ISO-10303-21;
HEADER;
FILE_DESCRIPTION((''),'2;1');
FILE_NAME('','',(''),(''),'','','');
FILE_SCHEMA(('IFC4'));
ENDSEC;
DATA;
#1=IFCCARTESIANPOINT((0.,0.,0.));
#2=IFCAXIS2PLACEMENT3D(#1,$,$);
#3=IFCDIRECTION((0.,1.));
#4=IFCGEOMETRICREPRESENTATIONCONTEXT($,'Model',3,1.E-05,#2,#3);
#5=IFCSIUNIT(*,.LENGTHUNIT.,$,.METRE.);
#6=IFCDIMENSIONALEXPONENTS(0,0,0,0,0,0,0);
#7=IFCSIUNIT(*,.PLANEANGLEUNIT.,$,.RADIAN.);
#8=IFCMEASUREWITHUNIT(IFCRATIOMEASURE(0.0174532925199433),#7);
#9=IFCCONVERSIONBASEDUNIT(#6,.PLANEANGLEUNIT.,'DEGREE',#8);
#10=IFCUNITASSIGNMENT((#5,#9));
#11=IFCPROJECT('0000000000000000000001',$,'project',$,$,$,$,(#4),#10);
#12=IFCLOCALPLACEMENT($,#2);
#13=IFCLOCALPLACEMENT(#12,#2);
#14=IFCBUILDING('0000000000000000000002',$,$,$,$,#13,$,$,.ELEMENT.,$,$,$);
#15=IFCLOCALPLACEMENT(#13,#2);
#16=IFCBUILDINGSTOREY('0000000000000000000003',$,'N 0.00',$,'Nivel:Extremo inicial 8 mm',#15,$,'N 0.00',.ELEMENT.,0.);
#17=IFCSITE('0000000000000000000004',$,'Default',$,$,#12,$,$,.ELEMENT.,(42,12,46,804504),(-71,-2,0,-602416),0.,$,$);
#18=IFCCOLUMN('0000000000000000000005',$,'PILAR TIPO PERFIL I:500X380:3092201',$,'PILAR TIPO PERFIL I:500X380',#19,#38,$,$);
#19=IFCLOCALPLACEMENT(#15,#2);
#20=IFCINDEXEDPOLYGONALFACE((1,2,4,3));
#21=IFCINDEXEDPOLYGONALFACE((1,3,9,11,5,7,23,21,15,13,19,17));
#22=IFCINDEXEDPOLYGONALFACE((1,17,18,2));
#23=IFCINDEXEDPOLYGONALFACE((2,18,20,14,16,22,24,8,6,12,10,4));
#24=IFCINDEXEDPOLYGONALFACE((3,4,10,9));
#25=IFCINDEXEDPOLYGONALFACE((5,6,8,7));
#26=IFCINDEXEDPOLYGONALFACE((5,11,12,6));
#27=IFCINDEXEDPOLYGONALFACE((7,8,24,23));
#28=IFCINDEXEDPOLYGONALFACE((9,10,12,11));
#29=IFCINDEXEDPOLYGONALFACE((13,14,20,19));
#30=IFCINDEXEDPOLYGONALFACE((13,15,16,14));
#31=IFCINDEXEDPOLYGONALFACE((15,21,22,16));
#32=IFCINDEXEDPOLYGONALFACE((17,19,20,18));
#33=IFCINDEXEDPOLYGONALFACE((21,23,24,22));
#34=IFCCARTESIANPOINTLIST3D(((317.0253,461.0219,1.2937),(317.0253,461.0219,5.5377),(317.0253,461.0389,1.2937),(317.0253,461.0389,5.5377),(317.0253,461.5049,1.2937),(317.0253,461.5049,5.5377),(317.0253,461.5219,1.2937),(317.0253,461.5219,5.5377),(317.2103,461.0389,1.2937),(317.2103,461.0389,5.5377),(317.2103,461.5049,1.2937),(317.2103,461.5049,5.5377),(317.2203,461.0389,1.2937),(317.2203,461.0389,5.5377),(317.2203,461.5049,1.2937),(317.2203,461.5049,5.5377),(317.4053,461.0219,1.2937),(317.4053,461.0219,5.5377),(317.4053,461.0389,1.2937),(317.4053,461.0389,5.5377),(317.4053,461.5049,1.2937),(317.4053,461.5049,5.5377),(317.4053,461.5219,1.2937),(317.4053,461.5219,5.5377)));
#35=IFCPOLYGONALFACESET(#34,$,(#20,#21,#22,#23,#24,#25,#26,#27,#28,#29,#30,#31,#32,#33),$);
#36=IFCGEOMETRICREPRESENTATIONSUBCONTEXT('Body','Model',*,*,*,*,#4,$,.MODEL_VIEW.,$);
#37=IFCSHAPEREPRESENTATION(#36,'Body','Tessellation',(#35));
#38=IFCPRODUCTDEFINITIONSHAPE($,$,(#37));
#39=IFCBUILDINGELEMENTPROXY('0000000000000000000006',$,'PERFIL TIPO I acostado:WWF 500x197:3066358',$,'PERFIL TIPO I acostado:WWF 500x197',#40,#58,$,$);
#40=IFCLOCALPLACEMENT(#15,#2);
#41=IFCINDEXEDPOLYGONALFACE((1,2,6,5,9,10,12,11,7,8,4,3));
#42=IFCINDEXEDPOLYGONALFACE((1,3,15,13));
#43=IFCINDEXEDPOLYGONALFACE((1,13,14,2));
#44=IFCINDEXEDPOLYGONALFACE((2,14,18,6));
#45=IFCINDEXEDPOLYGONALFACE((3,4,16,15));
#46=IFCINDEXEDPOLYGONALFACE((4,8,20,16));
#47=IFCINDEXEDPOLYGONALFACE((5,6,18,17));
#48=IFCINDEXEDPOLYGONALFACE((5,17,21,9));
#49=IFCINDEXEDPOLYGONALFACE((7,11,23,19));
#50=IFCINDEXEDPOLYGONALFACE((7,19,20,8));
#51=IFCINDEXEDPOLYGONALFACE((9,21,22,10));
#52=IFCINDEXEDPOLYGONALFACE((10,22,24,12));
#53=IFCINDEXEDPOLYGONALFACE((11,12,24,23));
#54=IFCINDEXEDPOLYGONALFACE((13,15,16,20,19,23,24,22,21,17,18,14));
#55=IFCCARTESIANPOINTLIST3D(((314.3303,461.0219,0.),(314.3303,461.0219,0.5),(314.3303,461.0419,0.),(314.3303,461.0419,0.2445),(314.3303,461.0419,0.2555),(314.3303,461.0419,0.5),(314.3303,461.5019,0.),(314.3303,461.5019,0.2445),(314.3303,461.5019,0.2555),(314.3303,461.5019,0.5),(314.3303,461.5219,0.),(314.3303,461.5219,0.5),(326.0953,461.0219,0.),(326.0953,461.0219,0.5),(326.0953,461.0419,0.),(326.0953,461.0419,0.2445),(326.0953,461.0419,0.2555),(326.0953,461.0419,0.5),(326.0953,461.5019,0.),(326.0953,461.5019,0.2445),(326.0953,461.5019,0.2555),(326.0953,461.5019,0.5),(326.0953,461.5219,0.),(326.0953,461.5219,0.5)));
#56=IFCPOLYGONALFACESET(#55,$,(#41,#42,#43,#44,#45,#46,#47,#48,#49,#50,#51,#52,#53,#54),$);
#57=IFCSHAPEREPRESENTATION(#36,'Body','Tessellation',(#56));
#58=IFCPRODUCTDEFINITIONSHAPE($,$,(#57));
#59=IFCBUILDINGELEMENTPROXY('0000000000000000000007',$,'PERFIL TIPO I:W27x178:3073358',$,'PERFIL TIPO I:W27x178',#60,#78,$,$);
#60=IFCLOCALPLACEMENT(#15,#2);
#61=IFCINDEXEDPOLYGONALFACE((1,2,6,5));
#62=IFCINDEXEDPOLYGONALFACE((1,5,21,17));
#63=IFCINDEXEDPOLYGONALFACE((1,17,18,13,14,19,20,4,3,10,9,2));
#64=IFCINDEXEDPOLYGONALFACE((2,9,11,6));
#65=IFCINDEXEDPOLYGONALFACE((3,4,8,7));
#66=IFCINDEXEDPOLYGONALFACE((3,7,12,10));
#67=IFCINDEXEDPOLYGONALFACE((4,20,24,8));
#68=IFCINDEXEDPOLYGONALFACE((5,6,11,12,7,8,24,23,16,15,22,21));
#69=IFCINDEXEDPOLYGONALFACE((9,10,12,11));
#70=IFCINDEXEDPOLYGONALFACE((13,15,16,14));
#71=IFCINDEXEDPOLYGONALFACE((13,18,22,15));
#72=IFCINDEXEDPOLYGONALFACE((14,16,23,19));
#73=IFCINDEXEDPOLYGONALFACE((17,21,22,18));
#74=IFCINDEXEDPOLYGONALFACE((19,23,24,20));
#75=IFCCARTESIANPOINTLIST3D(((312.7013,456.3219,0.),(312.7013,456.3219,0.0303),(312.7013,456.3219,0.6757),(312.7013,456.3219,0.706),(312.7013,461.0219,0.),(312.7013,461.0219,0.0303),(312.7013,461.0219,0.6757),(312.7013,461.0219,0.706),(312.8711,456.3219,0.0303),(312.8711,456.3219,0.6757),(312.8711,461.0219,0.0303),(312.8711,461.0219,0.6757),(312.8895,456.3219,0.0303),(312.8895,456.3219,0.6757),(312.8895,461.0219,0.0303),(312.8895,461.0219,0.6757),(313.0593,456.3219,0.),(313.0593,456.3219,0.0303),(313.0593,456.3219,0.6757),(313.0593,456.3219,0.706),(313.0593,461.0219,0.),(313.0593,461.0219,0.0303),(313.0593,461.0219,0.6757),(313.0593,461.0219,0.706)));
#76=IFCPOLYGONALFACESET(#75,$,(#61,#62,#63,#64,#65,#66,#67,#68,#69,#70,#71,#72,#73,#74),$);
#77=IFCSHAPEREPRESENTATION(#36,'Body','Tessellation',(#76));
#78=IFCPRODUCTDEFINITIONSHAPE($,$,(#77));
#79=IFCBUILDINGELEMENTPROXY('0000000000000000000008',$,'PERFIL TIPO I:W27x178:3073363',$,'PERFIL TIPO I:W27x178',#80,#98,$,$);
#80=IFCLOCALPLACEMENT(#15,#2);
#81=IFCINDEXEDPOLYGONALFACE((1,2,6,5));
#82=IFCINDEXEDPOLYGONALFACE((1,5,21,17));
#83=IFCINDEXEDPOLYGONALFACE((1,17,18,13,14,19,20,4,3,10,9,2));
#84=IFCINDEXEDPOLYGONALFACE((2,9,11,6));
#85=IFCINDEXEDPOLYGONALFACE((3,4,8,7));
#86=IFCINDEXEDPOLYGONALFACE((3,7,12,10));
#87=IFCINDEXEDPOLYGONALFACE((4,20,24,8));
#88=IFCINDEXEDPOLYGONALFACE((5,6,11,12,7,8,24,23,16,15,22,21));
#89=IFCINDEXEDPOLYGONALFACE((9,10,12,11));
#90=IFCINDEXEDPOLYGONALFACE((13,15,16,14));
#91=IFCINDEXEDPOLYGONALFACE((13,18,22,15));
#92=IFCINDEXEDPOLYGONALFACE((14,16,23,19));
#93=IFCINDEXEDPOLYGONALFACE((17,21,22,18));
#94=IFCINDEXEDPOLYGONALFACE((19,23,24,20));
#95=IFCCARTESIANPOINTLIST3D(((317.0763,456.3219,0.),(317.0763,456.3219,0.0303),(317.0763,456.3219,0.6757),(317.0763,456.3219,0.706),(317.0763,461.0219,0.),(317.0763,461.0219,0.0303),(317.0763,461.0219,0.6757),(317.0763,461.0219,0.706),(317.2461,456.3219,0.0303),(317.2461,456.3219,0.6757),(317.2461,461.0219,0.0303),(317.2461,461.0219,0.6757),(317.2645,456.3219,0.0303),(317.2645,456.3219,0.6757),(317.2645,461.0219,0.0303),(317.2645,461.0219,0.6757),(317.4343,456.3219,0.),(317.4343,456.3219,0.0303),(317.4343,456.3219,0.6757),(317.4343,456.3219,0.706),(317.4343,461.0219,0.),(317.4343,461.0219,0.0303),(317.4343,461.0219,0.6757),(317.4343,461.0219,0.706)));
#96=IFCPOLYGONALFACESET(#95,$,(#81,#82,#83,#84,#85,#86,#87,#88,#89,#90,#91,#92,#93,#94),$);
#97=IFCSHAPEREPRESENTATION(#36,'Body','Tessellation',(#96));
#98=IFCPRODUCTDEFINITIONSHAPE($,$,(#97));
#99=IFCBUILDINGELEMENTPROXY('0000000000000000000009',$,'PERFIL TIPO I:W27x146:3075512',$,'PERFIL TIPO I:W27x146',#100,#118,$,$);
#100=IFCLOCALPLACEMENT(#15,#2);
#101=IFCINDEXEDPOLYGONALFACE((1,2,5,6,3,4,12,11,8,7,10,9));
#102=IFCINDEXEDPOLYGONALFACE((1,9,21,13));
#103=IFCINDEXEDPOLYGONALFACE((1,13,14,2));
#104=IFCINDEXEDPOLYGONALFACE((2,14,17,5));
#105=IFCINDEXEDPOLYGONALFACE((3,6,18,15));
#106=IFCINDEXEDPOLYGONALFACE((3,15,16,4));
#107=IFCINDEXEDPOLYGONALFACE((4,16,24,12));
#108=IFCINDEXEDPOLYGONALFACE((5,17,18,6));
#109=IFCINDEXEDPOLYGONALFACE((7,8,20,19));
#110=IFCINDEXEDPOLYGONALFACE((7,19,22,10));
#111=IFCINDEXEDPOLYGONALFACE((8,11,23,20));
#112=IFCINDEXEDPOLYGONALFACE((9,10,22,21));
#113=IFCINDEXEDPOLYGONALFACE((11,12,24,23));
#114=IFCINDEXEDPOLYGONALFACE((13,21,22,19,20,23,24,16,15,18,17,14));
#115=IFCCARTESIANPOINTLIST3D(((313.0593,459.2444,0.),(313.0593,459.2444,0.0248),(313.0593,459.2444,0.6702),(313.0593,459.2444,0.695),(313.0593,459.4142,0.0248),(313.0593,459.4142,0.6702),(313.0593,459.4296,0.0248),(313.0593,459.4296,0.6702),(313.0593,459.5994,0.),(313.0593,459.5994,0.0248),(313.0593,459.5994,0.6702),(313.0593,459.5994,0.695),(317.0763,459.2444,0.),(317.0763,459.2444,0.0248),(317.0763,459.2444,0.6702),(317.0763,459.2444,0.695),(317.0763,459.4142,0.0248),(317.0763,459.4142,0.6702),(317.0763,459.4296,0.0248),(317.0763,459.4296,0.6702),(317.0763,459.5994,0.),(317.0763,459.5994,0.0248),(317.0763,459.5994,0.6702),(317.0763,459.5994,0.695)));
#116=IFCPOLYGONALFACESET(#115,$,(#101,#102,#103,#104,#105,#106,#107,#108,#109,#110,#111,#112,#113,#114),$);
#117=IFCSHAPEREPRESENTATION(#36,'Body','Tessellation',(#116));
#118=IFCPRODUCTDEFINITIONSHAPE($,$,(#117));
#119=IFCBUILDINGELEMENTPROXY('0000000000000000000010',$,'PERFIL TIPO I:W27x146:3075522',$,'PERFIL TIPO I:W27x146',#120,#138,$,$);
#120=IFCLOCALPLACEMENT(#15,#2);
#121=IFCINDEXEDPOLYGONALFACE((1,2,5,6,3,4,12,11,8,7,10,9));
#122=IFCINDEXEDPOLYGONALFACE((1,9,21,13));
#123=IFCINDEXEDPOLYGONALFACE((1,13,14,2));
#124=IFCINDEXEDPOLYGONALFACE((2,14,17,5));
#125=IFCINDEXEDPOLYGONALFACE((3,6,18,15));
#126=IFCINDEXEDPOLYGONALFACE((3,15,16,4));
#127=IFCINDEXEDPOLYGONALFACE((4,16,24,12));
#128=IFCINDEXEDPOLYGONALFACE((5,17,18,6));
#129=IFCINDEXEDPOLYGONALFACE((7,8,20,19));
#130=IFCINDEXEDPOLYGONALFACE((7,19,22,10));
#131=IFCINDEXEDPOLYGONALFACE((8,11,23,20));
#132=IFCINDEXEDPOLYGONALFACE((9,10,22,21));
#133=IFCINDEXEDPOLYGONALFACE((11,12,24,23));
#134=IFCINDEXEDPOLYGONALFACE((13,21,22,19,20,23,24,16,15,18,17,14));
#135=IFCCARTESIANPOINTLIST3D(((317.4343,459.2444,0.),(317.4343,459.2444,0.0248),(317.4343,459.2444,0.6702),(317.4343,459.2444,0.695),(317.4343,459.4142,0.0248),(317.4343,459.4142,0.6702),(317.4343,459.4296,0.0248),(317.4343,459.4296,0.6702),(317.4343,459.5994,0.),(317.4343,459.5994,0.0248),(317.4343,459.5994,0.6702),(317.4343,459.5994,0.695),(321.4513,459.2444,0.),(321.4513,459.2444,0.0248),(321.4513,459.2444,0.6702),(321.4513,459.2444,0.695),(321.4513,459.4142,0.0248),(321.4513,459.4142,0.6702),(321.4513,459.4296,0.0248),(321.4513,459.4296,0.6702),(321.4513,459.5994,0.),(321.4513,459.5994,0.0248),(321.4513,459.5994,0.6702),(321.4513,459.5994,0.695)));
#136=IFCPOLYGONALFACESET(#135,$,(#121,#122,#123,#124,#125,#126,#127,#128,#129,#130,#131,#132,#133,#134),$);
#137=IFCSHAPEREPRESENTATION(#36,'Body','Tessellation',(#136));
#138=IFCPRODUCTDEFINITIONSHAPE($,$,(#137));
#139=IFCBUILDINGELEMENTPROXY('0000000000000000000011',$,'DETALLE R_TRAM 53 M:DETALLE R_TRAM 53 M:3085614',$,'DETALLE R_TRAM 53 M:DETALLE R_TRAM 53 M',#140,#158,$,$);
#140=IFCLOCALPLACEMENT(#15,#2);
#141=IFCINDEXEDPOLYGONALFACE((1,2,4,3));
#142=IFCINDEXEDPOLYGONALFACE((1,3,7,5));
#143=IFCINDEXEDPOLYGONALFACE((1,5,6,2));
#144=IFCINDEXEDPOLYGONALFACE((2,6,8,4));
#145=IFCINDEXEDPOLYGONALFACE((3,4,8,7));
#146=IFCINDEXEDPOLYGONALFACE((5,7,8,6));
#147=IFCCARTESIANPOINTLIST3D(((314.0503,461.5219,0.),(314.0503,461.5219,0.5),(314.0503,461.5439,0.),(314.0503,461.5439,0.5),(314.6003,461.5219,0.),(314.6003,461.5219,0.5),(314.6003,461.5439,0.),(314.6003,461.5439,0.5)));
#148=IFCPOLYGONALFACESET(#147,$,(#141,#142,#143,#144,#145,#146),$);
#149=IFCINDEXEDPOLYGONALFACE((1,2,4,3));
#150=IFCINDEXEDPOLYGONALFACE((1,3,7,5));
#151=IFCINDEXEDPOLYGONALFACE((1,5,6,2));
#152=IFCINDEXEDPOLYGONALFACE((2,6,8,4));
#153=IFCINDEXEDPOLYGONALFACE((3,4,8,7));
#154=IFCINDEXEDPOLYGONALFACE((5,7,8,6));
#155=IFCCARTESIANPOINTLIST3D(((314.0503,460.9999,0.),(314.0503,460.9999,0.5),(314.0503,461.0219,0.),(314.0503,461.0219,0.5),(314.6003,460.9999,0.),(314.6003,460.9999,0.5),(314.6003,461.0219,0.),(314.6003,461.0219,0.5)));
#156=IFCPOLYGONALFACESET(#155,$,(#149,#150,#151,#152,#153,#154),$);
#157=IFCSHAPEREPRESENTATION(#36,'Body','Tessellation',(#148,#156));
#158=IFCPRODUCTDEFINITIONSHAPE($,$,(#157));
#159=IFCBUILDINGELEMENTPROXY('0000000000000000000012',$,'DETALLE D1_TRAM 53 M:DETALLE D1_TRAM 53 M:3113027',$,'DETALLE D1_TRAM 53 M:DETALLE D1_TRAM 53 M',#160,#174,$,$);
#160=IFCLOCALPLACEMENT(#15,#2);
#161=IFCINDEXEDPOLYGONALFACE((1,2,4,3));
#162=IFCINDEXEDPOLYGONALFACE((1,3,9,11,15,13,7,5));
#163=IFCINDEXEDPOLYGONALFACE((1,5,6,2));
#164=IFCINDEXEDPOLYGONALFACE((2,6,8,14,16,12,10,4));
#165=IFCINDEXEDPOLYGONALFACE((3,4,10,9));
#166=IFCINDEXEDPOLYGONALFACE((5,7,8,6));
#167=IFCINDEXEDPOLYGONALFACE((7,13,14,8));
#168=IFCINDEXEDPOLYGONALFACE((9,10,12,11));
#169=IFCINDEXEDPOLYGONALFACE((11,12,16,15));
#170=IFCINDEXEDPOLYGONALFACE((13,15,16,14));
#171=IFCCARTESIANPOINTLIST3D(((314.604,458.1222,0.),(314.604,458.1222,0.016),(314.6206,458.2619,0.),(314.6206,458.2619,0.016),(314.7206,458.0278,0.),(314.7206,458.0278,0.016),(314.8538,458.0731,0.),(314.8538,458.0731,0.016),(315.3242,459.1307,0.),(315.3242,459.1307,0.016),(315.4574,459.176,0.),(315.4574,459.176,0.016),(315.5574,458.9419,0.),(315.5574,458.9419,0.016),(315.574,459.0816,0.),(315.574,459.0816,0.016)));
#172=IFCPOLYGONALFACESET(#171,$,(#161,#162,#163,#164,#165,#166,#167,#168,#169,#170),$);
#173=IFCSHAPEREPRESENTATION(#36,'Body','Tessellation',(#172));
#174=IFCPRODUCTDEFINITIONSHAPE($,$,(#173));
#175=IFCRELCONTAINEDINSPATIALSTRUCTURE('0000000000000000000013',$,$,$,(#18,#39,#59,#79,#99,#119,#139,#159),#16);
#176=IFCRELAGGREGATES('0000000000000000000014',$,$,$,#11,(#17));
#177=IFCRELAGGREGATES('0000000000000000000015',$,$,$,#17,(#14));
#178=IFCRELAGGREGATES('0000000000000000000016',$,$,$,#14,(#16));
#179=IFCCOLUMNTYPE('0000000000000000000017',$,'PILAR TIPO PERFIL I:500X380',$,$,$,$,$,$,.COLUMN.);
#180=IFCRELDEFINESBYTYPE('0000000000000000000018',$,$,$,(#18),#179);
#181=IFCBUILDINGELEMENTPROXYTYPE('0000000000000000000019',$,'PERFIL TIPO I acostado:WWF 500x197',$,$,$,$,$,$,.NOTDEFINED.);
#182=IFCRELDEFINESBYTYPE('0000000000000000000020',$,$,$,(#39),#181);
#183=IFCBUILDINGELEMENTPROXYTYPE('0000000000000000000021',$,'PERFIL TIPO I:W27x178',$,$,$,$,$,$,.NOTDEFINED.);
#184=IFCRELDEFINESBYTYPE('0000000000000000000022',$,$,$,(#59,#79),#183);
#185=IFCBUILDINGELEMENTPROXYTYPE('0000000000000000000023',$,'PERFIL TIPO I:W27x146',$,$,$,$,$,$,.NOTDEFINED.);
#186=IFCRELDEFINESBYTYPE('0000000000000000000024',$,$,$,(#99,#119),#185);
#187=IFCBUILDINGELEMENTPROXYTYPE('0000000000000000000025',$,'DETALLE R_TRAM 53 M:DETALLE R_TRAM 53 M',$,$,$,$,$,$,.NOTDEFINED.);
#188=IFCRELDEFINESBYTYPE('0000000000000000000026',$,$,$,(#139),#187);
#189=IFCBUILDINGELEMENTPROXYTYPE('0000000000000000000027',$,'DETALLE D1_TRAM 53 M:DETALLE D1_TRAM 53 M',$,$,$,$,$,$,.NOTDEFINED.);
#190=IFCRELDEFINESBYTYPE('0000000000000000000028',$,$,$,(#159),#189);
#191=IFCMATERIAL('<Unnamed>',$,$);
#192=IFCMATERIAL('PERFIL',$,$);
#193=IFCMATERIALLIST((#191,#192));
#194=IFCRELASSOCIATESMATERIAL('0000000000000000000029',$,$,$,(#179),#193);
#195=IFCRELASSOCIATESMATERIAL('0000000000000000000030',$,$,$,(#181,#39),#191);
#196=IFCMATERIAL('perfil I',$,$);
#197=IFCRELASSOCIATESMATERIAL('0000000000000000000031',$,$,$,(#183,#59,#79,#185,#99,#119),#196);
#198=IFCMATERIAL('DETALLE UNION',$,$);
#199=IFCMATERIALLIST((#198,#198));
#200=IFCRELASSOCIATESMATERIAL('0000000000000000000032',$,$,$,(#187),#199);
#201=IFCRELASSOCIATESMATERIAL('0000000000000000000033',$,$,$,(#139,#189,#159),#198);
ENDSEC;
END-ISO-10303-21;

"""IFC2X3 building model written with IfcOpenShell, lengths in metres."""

from ifc_helpers import new_model, entity, si_unit, converted_unit, direction, frame, frame_2d, origin, place, context, subcontext, project, spatial, polyline, rectangle, i_section, outline, extrude, source, transform, mapped, material, material_list, type_object, type_shapes, element, save


model = new_model("IFC2X3")

# Units and contexts
model_context = context("Model", 3, precision=1e-05, world=origin(), true_north=direction((0.0, 1.0)))
body_context = subcontext(model_context, "Body", "Model", "MODEL_VIEW")
ifc_project = project(units=[si_unit("LENGTHUNIT", "METRE"), converted_unit("PLANEANGLEUNIT", "DEGREE", entity("IfcRatioMeasure", 0.0174532925199433), si_unit("PLANEANGLEUNIT", "RADIAN"), dimensions=[0, 0, 0, 0, 0, 0, 0])], contexts=[model_context])

# Site, building, storey
site_placement = place(None, origin())
site = spatial("IfcSite", under=ifc_project, at=site_placement, Name="Default", CompositionType="ELEMENT", RefLatitude=(42, 12, 46, 804504), RefLongitude=(-71, -2, 0, -602416), RefElevation=0.0)
building_placement = place(site_placement, origin())
building = spatial("IfcBuilding", under=site, at=building_placement, CompositionType="ELEMENT")
storey_placement = place(building_placement, origin())
storey = spatial("IfcBuildingStorey", under=building, at=storey_placement, Name="N 0.00", ObjectType="Nivel:Extremo inicial 8 mm", LongName="N 0.00", CompositionType="ELEMENT", Elevation=0.0)

# Column
ifc_material_1 = material(Name="<Unnamed>")
ifc_material_2 = material(Name="PERFIL")
ifc_material_list_1 = material_list([ifc_material_1, ifc_material_2])
column_type = type_object("IfcColumnType", Name="PILAR TIPO PERFIL I:500X380", PredefinedType="COLUMN", material=ifc_material_list_1)
shared_shape_1 = source(origin(), body_context, "Body", "SweptSolid", [
    extrude(i_section(OverallWidth=0.38, OverallDepth=0.5, WebThickness=0.01, FlangeThickness=0.017, at=frame_2d((0.0, 0.0), x_axis=(1.0, 0.0))), frame((0.0, 0.0, 1.2937), z_axis=(0.0, 0.0, 1.0), x_axis=(0.0, -1.0, 0.0)), (0.0, 0.0, 1.0), 4.244),
])
type_shapes(column_type, [shared_shape_1])
column_placement = place(storey_placement, frame((317.2153, 461.2719, 0.0), z_axis=(0.0, 0.0, 1.0), x_axis=(0.0, -1.0, 0.0)))
element("IfcColumn", 1, at=column_placement, inside=storey, type_object=column_type, Name="PILAR TIPO PERFIL I:500X380:3092201", ObjectType="PILAR TIPO PERFIL I:500X380", context=body_context, shape_type="MappedRepresentation", body=[
    mapped(shared_shape_1, transform((0.0, 0.0, 0.0), scale=1.0)),
])

# Building element proxies
building_element_proxy_type_1 = type_object("IfcBuildingElementProxyType", Name="PERFIL TIPO I acostado:WWF 500x197", PredefinedType="NOTDEFINED", material=ifc_material_1)
shared_shape_2 = source(origin(), body_context, "Body", "SweptSolid", [
    extrude(outline(polyline([(-0.25, -0.23), (-0.25, -0.25), (0.25, -0.25), (0.25, -0.23), (0.0055, -0.23), (0.0055, 0.23), (0.25, 0.23), (0.25, 0.25), (-0.25, 0.25), (-0.25, 0.23), (-0.0055, 0.23), (-0.0055, -0.23), (-0.25, -0.23)])), frame((0.0, 0.0, 0.25), z_axis=(-1.0, 0.0, 0.0), x_axis=(0.0, 0.0, -1.0)), (0.0, 0.0, -1.0), 11.765),
])
type_shapes(building_element_proxy_type_1, [shared_shape_2])
proxy_1_placement = place(storey_placement, frame((314.3303, 461.2719, 0.0)))
element("IfcBuildingElementProxy", 2, at=proxy_1_placement, inside=storey, type_object=building_element_proxy_type_1, material=ifc_material_1, Name="PERFIL TIPO I acostado:WWF 500x197:3066358", ObjectType="PERFIL TIPO I acostado:WWF 500x197", context=body_context, shape_type="MappedRepresentation", body=[
    mapped(shared_shape_2, transform((0.0, 0.0, 0.0), scale=1.0)),
])
ifc_material_3 = material(Name="perfil I")
building_element_proxy_type_2 = type_object("IfcBuildingElementProxyType", Name="PERFIL TIPO I:W27x178", PredefinedType="NOTDEFINED", material=ifc_material_3)
shared_shape_3 = source(origin(), body_context, "Body", "SweptSolid", [
    extrude(outline(polyline([(0.3227, -0.179), (0.353, -0.179), (0.353, 0.179), (0.3227, 0.179), (0.3227, 0.0092), (-0.3227, 0.0092), (-0.3227, 0.179), (-0.353, 0.179), (-0.353, -0.179), (-0.3227, -0.179), (-0.3227, -0.0092), (0.3227, -0.0092), (0.3227, -0.179)])), frame((0.0, 0.0, 0.353), z_axis=(1.0, 0.0, 0.0), x_axis=(0.0, 0.0, 1.0)), (0.0, 0.0, 1.0), 4.7),
])
type_shapes(building_element_proxy_type_2, [shared_shape_3])
for number, where, z_axis, x_axis, name in (
    (3, (312.8803, 461.0219, 0.0), (0.0, 0.0, 1.0), (0.0, -1.0, 0.0), "PERFIL TIPO I:W27x178:3073358"),
    (4, (317.2553, 461.0219, 0.0), (0.0, 0.0, 1.0), (0.0, -1.0, 0.0), "PERFIL TIPO I:W27x178:3073363"),
):
    element("IfcBuildingElementProxy", number, at=place(storey_placement, frame(where, z_axis=z_axis, x_axis=x_axis)), inside=storey, type_object=building_element_proxy_type_2, material=ifc_material_3, Name=name, ObjectType="PERFIL TIPO I:W27x178", context=body_context, shape_type="MappedRepresentation", body=[
        mapped(shared_shape_3, transform((0.0, 0.0, 0.0), scale=1.0)),
    ])
building_element_proxy_type_3 = type_object("IfcBuildingElementProxyType", Name="PERFIL TIPO I:W27x146", PredefinedType="NOTDEFINED", material=ifc_material_3)
shared_shape_4 = source(origin(), body_context, "Body", "SweptSolid", [
    extrude(outline(polyline([(0.3227, -0.1775), (0.3475, -0.1775), (0.3475, 0.1775), (0.3227, 0.1775), (0.3227, 0.0077), (-0.3227, 0.0077), (-0.3227, 0.1775), (-0.3475, 0.1775), (-0.3475, -0.1775), (-0.3227, -0.1775), (-0.3227, -0.0077), (0.3227, -0.0077), (0.3227, -0.1775)])), frame((0.0, 0.0, 0.3475), z_axis=(1.0, 0.0, 0.0), x_axis=(0.0, 0.0, 1.0)), (0.0, 0.0, 1.0), 4.017),
])
type_shapes(building_element_proxy_type_3, [shared_shape_4])
for number, where, name in (
    (5, (313.0593, 459.4219, 0.0), "PERFIL TIPO I:W27x146:3075512"),
    (6, (317.4343, 459.4219, 0.0), "PERFIL TIPO I:W27x146:3075522"),
):
    element("IfcBuildingElementProxy", number, at=place(storey_placement, frame(where)), inside=storey, type_object=building_element_proxy_type_3, material=ifc_material_3, Name=name, ObjectType="PERFIL TIPO I:W27x146", context=body_context, shape_type="MappedRepresentation", body=[
        mapped(shared_shape_4, transform((0.0, 0.0, 0.0), scale=1.0)),
    ])
ifc_material_4 = material(Name="DETALLE UNION")
ifc_material_list_2 = material_list([ifc_material_4, ifc_material_4])
building_element_proxy_type_4 = type_object("IfcBuildingElementProxyType", Name="DETALLE R_TRAM 53 M:DETALLE R_TRAM 53 M", PredefinedType="NOTDEFINED", material=ifc_material_list_2)
shared_shape_5 = source(origin(), body_context, "Body", "SweptSolid", [
    extrude(rectangle(XDim=0.55, YDim=0.022, at=frame_2d((0.0, 0.0), x_axis=(1.0, 0.0))), frame((0.275, 0.011, 0.0), z_axis=(0.0, 0.0, 1.0), x_axis=(-1.0, 0.0, 0.0)), (0.0, 0.0, 1.0), 0.5),
    extrude(rectangle(XDim=0.55, YDim=0.022, at=frame_2d((0.0, 0.0), x_axis=(1.0, 0.0))), frame((0.275, -0.511, 0.0), z_axis=(0.0, 0.0, 1.0), x_axis=(-1.0, 0.0, 0.0)), (0.0, 0.0, 1.0), 0.5),
])
type_shapes(building_element_proxy_type_4, [shared_shape_5])
proxy_2_placement = place(storey_placement, frame((314.0503, 461.5219, 0.0)))
element("IfcBuildingElementProxy", 7, at=proxy_2_placement, inside=storey, type_object=building_element_proxy_type_4, material=ifc_material_4, Name="DETALLE R_TRAM 53 M:DETALLE R_TRAM 53 M:3085614", ObjectType="DETALLE R_TRAM 53 M:DETALLE R_TRAM 53 M", context=body_context, shape_type="MappedRepresentation", body=[
    mapped(shared_shape_5, transform((0.0, 0.0, 0.0), scale=1.0)),
])
building_element_proxy_type_5 = type_object("IfcBuildingElementProxyType", Name="DETALLE D1_TRAM 53 M:DETALLE D1_TRAM 53 M", PredefinedType="NOTDEFINED", material=ifc_material_4)
shared_shape_6 = source(origin(), body_context, "Body", "SweptSolid", [
    extrude(outline(polyline([(-0.075, -0.678), (0.075, -0.678), (0.15, -0.559), (0.15, 0.559), (0.075, 0.678), (-0.075, 0.678), (-0.15, 0.559), (-0.15, -0.559), (-0.075, -0.678)])), frame((0.0, 0.0, 0.0), z_axis=(0.0, 0.0, 1.0), x_axis=(-0.777146, 0.62932, 0.0)), (0.0, 0.0, 1.0), 0.016),
])
type_shapes(building_element_proxy_type_5, [shared_shape_6])
proxy_3_placement = place(storey_placement, frame((315.089, 458.6019, 0.0)))
element("IfcBuildingElementProxy", 8, at=proxy_3_placement, inside=storey, type_object=building_element_proxy_type_5, material=ifc_material_4, Name="DETALLE D1_TRAM 53 M:DETALLE D1_TRAM 53 M:3113027", ObjectType="DETALLE D1_TRAM 53 M:DETALLE D1_TRAM 53 M", context=body_context, shape_type="MappedRepresentation", body=[
    mapped(shared_shape_6, transform((0.0, 0.0, 0.0), scale=1.0)),
])

save(model, "model.ifc")
